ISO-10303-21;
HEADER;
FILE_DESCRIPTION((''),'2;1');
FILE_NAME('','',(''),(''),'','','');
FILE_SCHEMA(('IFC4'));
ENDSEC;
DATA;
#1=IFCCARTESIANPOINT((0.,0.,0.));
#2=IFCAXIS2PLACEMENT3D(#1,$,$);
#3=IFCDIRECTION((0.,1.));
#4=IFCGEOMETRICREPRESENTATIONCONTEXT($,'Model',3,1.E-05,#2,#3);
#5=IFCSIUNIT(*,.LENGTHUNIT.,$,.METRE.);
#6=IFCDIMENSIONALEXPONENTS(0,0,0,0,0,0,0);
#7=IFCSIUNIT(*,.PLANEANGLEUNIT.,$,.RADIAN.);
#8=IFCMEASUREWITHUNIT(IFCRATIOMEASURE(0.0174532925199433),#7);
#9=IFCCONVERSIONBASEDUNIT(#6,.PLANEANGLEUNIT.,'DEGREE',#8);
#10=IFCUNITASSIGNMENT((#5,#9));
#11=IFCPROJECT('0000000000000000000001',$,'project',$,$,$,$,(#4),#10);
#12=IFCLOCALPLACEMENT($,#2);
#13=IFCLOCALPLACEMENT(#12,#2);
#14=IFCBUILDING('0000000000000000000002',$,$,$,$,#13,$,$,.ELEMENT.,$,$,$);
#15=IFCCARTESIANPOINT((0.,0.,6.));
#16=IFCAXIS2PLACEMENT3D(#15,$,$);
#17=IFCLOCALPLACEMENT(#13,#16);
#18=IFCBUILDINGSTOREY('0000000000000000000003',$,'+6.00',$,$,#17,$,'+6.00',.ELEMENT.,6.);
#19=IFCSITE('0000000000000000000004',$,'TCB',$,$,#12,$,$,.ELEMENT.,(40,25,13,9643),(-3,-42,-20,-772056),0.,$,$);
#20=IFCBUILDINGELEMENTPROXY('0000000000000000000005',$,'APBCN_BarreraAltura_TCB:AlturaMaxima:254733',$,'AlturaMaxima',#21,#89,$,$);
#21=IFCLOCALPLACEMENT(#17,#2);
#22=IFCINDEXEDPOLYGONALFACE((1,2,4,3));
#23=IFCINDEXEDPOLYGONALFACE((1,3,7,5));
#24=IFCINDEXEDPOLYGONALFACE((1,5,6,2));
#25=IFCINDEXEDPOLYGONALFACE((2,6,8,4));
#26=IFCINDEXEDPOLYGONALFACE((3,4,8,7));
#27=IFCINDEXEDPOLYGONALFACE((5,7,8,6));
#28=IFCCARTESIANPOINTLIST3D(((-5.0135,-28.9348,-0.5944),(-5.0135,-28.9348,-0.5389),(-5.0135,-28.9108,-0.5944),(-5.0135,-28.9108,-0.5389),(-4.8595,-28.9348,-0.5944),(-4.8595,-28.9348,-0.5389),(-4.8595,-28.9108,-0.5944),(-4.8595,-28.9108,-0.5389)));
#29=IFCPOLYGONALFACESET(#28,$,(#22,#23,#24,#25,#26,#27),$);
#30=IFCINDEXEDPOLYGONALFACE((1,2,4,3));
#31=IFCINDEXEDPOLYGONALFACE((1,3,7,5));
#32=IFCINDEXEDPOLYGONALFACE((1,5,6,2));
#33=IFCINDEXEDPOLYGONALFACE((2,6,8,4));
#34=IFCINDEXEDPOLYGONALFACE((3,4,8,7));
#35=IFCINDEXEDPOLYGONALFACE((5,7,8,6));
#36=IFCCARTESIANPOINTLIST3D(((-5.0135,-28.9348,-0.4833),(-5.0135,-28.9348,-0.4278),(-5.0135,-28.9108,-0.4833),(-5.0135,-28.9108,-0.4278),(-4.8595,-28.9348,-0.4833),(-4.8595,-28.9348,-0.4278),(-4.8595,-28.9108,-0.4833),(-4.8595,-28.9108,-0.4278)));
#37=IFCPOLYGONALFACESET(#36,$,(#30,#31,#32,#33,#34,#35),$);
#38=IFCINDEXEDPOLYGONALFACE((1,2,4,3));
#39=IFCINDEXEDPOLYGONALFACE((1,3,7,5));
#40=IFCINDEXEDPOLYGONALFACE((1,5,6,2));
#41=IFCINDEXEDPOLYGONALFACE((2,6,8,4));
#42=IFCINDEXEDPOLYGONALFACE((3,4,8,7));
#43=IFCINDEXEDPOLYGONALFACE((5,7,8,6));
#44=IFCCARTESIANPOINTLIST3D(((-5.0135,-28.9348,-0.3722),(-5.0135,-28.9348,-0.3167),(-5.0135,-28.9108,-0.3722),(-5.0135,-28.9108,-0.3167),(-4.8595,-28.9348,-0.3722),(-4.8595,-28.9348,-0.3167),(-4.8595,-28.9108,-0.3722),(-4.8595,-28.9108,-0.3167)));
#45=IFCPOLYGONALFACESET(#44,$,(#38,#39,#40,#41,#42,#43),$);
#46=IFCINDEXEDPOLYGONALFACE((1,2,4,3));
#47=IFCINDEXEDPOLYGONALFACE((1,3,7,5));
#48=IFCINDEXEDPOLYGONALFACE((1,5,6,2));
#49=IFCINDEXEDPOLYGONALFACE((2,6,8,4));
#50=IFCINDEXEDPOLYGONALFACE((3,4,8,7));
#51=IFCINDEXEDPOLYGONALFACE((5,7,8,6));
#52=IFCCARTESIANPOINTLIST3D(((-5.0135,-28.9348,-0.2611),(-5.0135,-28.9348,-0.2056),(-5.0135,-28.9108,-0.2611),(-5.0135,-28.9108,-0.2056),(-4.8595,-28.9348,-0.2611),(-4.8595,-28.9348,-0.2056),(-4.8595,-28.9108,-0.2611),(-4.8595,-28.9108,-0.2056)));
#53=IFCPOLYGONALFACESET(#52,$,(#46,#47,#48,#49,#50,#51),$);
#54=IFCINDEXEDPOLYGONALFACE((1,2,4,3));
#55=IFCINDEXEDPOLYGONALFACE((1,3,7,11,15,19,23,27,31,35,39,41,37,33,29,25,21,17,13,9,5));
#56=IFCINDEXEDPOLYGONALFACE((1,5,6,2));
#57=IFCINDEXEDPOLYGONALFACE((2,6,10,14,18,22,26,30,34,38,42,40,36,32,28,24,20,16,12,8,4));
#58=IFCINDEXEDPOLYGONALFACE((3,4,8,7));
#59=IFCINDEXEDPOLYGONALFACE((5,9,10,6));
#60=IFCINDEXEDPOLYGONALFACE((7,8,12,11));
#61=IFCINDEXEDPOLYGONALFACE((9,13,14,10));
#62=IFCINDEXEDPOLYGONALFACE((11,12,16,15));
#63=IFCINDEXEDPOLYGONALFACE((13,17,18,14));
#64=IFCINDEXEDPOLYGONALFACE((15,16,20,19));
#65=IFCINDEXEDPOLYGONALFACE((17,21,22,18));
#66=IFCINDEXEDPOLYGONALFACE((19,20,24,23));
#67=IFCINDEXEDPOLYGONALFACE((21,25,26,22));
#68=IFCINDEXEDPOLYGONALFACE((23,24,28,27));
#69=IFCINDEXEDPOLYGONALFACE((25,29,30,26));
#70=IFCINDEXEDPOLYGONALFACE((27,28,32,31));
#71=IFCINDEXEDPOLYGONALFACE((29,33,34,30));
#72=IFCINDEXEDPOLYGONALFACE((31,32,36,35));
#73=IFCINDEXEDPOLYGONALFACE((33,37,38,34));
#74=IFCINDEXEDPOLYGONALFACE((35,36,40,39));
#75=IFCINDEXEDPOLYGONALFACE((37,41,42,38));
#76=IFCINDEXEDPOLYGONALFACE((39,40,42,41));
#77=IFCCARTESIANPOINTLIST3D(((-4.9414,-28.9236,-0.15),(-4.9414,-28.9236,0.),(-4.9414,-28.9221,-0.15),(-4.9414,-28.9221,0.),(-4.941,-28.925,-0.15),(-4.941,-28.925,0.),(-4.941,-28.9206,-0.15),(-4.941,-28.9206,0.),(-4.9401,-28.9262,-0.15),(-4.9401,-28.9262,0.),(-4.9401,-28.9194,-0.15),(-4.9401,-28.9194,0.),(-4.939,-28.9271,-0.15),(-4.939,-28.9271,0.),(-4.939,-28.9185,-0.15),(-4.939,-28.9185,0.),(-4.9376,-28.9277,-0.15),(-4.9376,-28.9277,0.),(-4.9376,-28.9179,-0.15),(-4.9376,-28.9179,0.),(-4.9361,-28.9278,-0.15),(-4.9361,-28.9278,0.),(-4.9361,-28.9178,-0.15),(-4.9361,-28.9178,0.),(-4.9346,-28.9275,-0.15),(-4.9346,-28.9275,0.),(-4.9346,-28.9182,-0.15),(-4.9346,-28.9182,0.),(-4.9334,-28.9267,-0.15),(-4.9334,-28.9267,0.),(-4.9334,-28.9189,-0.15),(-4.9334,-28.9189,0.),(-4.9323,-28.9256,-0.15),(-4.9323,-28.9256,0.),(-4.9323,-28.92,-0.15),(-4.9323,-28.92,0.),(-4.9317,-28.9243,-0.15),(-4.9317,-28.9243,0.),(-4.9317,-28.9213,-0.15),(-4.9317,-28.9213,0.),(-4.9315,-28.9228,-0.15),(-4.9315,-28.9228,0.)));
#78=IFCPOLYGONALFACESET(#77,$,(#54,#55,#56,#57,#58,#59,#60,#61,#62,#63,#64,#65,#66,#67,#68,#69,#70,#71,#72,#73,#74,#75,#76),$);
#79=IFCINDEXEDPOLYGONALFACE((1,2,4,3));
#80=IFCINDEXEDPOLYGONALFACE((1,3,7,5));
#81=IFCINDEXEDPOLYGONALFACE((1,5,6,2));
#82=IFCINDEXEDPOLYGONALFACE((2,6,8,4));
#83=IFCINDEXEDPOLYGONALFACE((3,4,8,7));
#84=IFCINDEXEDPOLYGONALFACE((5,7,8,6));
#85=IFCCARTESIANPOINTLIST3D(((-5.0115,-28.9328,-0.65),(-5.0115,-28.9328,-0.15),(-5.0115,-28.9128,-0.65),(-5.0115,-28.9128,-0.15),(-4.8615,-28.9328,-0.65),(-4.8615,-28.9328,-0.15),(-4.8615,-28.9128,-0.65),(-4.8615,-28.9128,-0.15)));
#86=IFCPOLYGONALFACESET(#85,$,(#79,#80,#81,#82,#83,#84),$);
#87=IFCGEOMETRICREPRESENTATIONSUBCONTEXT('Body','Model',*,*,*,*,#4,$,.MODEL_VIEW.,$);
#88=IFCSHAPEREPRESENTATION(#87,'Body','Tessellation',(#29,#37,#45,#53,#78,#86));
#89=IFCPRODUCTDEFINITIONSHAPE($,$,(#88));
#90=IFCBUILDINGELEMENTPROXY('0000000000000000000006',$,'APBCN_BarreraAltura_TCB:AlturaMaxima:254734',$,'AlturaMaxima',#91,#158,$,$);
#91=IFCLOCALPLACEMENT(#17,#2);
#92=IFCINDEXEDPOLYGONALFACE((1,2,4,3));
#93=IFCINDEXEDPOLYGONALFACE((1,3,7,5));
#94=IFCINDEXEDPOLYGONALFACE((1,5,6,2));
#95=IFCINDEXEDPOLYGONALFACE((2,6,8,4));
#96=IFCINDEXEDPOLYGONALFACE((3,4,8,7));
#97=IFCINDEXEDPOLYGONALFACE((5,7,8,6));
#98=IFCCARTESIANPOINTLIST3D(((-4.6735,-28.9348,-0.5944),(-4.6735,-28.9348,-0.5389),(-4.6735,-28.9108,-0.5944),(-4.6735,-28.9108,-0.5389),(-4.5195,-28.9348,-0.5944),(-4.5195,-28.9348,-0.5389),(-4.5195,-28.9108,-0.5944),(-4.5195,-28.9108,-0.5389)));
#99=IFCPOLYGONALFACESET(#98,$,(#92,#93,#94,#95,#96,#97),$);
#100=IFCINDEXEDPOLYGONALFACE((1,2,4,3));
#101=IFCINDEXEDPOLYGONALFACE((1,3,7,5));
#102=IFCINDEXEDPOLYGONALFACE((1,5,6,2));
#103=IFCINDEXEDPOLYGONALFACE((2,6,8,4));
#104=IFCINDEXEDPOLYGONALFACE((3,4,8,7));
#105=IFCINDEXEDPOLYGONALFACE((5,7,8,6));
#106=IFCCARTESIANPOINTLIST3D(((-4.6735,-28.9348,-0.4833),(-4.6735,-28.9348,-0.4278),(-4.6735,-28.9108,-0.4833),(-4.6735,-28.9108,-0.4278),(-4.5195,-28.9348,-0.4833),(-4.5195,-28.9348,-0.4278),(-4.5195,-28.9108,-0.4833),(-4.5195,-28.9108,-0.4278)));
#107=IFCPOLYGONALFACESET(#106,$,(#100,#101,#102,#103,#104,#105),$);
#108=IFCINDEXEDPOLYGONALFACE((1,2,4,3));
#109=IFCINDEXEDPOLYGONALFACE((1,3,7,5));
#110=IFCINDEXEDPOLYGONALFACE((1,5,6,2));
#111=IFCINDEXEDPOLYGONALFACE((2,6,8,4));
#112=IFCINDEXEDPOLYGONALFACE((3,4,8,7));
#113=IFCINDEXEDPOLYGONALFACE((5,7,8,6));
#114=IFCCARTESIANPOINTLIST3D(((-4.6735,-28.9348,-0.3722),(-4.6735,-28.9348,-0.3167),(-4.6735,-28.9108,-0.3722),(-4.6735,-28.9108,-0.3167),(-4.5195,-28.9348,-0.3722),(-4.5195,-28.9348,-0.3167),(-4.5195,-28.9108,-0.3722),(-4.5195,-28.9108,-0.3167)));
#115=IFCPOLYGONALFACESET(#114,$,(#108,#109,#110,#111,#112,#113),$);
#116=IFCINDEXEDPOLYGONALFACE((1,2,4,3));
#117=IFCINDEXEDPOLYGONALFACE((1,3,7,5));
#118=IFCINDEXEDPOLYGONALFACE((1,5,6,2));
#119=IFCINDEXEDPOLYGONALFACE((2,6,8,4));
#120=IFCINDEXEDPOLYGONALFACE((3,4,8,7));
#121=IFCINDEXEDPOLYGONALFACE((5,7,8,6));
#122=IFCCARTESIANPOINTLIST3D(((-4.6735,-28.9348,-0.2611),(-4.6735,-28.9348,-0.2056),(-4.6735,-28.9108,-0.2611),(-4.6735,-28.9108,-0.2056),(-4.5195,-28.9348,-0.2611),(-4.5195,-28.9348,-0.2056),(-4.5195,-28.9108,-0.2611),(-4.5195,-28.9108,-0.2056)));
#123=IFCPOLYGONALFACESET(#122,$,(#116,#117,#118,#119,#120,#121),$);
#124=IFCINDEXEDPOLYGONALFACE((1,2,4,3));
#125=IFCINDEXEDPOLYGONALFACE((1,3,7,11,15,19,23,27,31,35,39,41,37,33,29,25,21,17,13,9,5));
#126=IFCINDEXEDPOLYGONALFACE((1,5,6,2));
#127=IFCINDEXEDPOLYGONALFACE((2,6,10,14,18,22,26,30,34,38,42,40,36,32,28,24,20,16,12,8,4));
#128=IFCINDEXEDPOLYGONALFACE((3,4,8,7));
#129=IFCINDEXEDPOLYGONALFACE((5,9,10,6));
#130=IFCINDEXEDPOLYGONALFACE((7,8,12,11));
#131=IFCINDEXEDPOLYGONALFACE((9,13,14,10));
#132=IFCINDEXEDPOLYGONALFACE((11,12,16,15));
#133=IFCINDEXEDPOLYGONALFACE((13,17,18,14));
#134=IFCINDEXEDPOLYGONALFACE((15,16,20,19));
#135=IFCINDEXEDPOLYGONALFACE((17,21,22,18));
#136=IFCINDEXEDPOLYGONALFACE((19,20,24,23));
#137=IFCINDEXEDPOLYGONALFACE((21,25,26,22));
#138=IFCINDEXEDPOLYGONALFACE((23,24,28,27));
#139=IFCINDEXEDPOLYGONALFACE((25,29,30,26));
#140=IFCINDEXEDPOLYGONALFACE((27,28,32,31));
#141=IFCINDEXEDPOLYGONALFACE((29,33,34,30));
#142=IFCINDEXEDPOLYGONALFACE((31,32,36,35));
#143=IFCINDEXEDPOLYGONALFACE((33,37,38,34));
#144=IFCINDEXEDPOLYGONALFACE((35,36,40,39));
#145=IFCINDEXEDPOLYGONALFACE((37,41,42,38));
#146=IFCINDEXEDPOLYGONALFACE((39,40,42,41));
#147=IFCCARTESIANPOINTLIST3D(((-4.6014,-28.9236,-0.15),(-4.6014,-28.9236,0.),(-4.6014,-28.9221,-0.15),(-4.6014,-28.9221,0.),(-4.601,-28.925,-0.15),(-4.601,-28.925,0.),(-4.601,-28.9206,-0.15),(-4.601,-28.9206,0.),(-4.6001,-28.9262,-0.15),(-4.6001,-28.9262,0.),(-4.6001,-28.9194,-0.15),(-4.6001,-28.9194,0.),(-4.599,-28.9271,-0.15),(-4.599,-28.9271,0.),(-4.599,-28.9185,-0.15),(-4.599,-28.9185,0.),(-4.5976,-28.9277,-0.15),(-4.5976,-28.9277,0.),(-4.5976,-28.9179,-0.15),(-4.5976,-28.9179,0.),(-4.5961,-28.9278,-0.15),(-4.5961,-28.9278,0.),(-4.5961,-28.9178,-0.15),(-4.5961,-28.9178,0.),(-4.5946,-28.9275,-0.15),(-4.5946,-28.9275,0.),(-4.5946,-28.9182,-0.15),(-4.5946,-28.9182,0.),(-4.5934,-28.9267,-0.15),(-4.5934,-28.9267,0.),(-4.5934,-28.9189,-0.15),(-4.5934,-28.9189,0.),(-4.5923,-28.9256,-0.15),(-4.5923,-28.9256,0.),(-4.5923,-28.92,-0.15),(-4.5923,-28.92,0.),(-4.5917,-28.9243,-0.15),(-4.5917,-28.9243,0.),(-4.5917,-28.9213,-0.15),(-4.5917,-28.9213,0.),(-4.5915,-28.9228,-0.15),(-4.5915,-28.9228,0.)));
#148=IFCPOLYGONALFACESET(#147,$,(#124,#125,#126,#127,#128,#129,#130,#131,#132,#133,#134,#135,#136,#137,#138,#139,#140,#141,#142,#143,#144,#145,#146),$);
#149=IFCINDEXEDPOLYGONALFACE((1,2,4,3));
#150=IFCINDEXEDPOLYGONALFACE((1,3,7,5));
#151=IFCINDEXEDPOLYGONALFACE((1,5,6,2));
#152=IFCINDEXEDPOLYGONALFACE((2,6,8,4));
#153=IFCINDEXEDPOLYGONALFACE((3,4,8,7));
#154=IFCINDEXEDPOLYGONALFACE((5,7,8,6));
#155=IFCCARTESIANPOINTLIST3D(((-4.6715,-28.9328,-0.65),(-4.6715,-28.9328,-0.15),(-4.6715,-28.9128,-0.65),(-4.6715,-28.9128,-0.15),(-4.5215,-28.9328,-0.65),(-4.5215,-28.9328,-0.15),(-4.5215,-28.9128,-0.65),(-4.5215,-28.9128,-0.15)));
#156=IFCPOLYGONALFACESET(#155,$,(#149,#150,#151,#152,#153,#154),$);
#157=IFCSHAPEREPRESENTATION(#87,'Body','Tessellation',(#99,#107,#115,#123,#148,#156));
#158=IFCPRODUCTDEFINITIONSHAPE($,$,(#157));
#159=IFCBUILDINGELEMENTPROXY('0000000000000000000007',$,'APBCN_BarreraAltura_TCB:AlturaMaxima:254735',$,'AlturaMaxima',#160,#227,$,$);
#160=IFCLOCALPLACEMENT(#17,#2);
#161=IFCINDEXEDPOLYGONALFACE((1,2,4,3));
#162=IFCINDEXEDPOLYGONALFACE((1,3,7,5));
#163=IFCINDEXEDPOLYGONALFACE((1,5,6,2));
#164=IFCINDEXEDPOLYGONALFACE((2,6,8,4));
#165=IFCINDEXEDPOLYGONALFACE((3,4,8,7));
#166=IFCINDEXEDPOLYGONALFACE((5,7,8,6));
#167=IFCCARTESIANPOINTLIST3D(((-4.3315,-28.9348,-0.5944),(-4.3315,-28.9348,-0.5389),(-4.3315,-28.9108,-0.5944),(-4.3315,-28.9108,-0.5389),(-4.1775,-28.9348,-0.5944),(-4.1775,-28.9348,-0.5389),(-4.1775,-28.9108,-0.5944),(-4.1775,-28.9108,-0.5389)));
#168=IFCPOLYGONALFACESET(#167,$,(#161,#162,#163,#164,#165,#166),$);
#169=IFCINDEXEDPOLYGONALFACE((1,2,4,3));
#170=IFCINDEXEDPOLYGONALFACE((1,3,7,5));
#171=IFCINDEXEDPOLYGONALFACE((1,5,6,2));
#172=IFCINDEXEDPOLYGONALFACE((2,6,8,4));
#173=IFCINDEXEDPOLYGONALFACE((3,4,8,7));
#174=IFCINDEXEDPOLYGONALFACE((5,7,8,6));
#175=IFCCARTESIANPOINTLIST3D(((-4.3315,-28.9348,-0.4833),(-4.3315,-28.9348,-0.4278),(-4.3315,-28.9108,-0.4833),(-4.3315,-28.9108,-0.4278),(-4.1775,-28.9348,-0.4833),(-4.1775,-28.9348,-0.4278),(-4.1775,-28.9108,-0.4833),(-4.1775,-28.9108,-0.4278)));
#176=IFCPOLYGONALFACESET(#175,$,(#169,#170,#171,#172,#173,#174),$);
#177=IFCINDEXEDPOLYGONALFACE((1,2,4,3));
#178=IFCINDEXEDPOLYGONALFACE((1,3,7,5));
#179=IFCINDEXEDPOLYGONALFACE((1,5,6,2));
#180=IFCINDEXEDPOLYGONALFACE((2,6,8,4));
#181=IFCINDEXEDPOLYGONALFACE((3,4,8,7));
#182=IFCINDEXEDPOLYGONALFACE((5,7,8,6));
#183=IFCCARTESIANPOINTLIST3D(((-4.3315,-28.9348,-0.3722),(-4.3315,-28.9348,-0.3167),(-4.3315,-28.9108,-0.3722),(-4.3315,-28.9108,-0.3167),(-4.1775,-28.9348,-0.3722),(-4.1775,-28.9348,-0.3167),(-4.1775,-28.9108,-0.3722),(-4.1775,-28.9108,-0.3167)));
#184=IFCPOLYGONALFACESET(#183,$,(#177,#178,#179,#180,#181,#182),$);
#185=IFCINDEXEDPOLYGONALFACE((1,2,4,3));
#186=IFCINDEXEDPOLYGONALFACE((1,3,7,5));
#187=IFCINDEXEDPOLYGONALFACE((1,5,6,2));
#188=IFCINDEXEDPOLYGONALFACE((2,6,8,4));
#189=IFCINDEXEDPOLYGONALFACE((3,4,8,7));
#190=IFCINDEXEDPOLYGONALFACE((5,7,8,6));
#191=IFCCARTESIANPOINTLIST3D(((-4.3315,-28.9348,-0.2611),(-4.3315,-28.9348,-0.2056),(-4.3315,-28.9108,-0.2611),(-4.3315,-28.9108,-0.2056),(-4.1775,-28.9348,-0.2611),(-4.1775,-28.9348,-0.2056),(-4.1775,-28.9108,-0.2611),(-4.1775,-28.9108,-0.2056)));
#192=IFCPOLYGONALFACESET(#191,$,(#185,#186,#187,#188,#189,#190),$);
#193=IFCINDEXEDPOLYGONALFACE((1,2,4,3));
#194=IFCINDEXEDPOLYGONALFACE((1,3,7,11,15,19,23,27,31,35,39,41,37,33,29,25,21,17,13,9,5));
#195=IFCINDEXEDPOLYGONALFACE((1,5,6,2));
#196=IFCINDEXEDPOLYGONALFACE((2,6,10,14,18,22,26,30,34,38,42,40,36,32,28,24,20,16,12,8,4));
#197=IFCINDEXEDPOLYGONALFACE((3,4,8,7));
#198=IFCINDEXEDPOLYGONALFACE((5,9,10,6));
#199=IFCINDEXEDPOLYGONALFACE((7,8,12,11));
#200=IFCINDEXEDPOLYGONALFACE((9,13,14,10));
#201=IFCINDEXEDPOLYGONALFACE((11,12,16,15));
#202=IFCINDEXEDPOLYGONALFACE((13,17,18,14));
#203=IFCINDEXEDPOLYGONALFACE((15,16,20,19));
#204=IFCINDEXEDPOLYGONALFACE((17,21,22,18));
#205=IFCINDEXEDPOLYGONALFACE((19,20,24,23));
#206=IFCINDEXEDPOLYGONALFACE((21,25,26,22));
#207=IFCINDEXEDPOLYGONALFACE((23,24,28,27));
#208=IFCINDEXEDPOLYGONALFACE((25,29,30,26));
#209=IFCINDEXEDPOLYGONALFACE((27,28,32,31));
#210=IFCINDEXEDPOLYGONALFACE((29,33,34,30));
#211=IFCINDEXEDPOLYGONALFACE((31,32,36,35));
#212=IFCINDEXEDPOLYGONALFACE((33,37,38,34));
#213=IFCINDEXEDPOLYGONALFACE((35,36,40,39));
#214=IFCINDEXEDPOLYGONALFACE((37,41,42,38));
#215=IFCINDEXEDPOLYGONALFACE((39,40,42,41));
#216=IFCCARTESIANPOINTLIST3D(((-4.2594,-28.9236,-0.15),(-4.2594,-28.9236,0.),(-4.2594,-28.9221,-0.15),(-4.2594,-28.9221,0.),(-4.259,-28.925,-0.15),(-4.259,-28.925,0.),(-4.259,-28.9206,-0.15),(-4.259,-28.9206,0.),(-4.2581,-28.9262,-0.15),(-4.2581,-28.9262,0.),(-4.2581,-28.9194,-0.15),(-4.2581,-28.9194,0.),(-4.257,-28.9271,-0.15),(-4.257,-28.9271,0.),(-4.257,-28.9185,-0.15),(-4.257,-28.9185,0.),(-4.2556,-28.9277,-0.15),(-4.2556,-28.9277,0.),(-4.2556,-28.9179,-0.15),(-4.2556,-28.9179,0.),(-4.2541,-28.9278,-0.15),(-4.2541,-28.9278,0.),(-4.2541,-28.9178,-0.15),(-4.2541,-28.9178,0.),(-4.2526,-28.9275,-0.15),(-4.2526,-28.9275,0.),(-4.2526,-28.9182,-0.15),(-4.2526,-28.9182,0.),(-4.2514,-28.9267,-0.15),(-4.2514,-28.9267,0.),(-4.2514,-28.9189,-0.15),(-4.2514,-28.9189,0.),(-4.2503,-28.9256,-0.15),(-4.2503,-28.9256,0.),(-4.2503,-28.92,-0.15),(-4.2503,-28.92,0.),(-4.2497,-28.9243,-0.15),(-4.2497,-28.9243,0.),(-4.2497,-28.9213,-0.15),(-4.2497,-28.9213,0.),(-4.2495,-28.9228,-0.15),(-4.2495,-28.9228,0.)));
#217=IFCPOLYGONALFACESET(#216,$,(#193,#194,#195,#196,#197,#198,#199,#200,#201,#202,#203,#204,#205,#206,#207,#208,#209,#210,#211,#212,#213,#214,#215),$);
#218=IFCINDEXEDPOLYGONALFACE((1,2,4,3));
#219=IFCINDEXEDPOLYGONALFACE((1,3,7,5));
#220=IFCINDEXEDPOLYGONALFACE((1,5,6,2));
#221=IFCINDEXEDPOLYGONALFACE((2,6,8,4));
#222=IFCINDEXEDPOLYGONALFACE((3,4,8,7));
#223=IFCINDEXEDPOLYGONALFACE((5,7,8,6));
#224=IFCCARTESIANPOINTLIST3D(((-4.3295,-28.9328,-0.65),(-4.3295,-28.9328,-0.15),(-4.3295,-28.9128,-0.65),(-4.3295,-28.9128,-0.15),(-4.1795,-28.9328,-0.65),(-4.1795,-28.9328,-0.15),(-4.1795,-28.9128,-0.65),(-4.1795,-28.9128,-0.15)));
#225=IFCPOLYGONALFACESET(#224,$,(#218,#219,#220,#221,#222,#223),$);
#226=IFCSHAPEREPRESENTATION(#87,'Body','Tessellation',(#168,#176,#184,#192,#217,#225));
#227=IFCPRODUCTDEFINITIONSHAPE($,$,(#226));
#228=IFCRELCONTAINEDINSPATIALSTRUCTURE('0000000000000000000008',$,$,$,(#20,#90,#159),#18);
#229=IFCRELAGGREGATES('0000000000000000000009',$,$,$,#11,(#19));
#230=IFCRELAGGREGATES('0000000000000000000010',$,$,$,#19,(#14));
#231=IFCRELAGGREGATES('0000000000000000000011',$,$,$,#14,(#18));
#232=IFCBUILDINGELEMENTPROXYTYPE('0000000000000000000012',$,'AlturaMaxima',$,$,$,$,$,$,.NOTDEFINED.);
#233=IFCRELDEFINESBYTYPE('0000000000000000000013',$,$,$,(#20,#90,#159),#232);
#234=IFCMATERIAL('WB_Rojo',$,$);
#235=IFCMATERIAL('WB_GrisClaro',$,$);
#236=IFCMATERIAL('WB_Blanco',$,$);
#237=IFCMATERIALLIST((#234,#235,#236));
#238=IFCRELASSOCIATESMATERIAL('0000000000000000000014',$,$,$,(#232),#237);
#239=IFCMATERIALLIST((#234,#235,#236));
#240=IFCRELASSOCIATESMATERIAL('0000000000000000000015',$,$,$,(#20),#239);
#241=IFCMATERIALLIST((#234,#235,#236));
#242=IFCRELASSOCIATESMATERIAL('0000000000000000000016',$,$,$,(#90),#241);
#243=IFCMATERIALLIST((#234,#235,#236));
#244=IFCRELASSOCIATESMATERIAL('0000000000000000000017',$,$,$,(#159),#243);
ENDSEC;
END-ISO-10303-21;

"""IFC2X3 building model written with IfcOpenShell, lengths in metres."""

from ifc_helpers import new_model, entity, si_unit, converted_unit, direction, frame, frame_2d, origin, origin_2d_with_axis, place, context, subcontext, project, spatial, rectangle, circle, extrude, source, transform, mapped, material, material_list, type_object, type_shapes, element, save


model = new_model("IFC2X3")

# Units and contexts
model_context = context("Model", 3, precision=1e-05, world=origin(), true_north=direction((0.0, 1.0)))
body_context = subcontext(model_context, "Body", "Model", "MODEL_VIEW")
ifc_project = project(units=[si_unit("LENGTHUNIT", "METRE"), converted_unit("PLANEANGLEUNIT", "DEGREE", entity("IfcRatioMeasure", 0.0174532925199433), si_unit("PLANEANGLEUNIT", "RADIAN"), dimensions=[0, 0, 0, 0, 0, 0, 0])], contexts=[model_context])

# Site, building, storey
site_placement = place(None, origin())
site = spatial("IfcSite", under=ifc_project, at=site_placement, Name="TCB", CompositionType="ELEMENT", RefLatitude=(40, 25, 13, 9643), RefLongitude=(-3, -42, -20, -772056), RefElevation=0.0)
building_placement = place(site_placement, origin())
building = spatial("IfcBuilding", under=site, at=building_placement, CompositionType="ELEMENT")
storey_placement = place(building_placement, frame((0.0, 0.0, 6.0)))
storey = spatial("IfcBuildingStorey", under=building, at=storey_placement, Name="+6.00", LongName="+6.00", CompositionType="ELEMENT", Elevation=6.0)

# Building element proxies
ifc_material_1 = material(Name="WB_Rojo")
ifc_material_2 = material(Name="WB_GrisClaro")
ifc_material_3 = material(Name="WB_Blanco")
ifc_material_list_1 = material_list([ifc_material_1, ifc_material_2, ifc_material_3])
building_element_proxy_type = type_object("IfcBuildingElementProxyType", Name="AlturaMaxima", PredefinedType="NOTDEFINED", material=ifc_material_list_1)
shared_shape = source(origin(), body_context, "Body", "SweptSolid", [
    extrude(rectangle(XDim=0.154, YDim=0.024, at=frame_2d((0.0, 0.0), x_axis=(1.0, 0.0))), frame((0.0, 0.0, -0.5944), z_axis=(0.0, 0.0, 1.0), x_axis=(-1.0, 0.0, 0.0)), (0.0, 0.0, 1.0), 0.0556),
    extrude(rectangle(XDim=0.154, YDim=0.024, at=frame_2d((0.0, 0.0), x_axis=(1.0, 0.0))), frame((0.0, 0.0, -0.4833), z_axis=(0.0, 0.0, 1.0), x_axis=(-1.0, 0.0, 0.0)), (0.0, 0.0, 1.0), 0.0556),
    extrude(rectangle(XDim=0.154, YDim=0.024, at=frame_2d((0.0, 0.0), x_axis=(1.0, 0.0))), frame((0.0, 0.0, -0.3722), z_axis=(0.0, 0.0, 1.0), x_axis=(-1.0, 0.0, 0.0)), (0.0, 0.0, 1.0), 0.0556),
    extrude(rectangle(XDim=0.154, YDim=0.024, at=frame_2d((0.0, 0.0), x_axis=(1.0, 0.0))), frame((0.0, 0.0, -0.2611), z_axis=(0.0, 0.0, 1.0), x_axis=(-1.0, 0.0, 0.0)), (0.0, 0.0, 1.0), 0.0556),
    extrude(circle(Radius=0.005, at=frame_2d((0.0, 0.0), x_axis=(1.0, 0.0))), frame((0.0, 0.0, -0.15)), (0.0, 0.0, 1.0), 0.15),
    extrude(rectangle(XDim=0.02, YDim=0.15, at=origin_2d_with_axis()), frame((0.0, 0.0, -0.65), z_axis=(0.0, 0.0, 1.0), x_axis=(0.0, 1.0, 0.0)), (0.0, 0.0, 1.0), 0.5),
])
type_shapes(building_element_proxy_type, [shared_shape])
ifc_material_list_2 = material_list([ifc_material_1, ifc_material_2, ifc_material_3])
proxy_1_placement = place(storey_placement, frame((-4.9365, -28.9228, 0.0)))
element("IfcBuildingElementProxy", 1, at=proxy_1_placement, inside=storey, type_object=building_element_proxy_type, material=ifc_material_list_2, Name="APBCN_BarreraAltura_TCB:AlturaMaxima:254733", ObjectType="AlturaMaxima", context=body_context, shape_type="MappedRepresentation", body=[
    mapped(shared_shape, transform((0.0, 0.0, 0.0), scale=1.0)),
])
ifc_material_list_3 = material_list([ifc_material_1, ifc_material_2, ifc_material_3])
proxy_2_placement = place(storey_placement, frame((-4.5965, -28.9228, 0.0)))
element("IfcBuildingElementProxy", 2, at=proxy_2_placement, inside=storey, type_object=building_element_proxy_type, material=ifc_material_list_3, Name="APBCN_BarreraAltura_TCB:AlturaMaxima:254734", ObjectType="AlturaMaxima", context=body_context, shape_type="MappedRepresentation", body=[
    mapped(shared_shape, transform((0.0, 0.0, 0.0), scale=1.0)),
])
ifc_material_list_4 = material_list([ifc_material_1, ifc_material_2, ifc_material_3])
proxy_3_placement = place(storey_placement, frame((-4.2545, -28.9228, 0.0)))
element("IfcBuildingElementProxy", 3, at=proxy_3_placement, inside=storey, type_object=building_element_proxy_type, material=ifc_material_list_4, Name="APBCN_BarreraAltura_TCB:AlturaMaxima:254735", ObjectType="AlturaMaxima", context=body_context, shape_type="MappedRepresentation", body=[
    mapped(shared_shape, transform((0.0, 0.0, 0.0), scale=1.0)),
])

save(model, "model.ifc")
